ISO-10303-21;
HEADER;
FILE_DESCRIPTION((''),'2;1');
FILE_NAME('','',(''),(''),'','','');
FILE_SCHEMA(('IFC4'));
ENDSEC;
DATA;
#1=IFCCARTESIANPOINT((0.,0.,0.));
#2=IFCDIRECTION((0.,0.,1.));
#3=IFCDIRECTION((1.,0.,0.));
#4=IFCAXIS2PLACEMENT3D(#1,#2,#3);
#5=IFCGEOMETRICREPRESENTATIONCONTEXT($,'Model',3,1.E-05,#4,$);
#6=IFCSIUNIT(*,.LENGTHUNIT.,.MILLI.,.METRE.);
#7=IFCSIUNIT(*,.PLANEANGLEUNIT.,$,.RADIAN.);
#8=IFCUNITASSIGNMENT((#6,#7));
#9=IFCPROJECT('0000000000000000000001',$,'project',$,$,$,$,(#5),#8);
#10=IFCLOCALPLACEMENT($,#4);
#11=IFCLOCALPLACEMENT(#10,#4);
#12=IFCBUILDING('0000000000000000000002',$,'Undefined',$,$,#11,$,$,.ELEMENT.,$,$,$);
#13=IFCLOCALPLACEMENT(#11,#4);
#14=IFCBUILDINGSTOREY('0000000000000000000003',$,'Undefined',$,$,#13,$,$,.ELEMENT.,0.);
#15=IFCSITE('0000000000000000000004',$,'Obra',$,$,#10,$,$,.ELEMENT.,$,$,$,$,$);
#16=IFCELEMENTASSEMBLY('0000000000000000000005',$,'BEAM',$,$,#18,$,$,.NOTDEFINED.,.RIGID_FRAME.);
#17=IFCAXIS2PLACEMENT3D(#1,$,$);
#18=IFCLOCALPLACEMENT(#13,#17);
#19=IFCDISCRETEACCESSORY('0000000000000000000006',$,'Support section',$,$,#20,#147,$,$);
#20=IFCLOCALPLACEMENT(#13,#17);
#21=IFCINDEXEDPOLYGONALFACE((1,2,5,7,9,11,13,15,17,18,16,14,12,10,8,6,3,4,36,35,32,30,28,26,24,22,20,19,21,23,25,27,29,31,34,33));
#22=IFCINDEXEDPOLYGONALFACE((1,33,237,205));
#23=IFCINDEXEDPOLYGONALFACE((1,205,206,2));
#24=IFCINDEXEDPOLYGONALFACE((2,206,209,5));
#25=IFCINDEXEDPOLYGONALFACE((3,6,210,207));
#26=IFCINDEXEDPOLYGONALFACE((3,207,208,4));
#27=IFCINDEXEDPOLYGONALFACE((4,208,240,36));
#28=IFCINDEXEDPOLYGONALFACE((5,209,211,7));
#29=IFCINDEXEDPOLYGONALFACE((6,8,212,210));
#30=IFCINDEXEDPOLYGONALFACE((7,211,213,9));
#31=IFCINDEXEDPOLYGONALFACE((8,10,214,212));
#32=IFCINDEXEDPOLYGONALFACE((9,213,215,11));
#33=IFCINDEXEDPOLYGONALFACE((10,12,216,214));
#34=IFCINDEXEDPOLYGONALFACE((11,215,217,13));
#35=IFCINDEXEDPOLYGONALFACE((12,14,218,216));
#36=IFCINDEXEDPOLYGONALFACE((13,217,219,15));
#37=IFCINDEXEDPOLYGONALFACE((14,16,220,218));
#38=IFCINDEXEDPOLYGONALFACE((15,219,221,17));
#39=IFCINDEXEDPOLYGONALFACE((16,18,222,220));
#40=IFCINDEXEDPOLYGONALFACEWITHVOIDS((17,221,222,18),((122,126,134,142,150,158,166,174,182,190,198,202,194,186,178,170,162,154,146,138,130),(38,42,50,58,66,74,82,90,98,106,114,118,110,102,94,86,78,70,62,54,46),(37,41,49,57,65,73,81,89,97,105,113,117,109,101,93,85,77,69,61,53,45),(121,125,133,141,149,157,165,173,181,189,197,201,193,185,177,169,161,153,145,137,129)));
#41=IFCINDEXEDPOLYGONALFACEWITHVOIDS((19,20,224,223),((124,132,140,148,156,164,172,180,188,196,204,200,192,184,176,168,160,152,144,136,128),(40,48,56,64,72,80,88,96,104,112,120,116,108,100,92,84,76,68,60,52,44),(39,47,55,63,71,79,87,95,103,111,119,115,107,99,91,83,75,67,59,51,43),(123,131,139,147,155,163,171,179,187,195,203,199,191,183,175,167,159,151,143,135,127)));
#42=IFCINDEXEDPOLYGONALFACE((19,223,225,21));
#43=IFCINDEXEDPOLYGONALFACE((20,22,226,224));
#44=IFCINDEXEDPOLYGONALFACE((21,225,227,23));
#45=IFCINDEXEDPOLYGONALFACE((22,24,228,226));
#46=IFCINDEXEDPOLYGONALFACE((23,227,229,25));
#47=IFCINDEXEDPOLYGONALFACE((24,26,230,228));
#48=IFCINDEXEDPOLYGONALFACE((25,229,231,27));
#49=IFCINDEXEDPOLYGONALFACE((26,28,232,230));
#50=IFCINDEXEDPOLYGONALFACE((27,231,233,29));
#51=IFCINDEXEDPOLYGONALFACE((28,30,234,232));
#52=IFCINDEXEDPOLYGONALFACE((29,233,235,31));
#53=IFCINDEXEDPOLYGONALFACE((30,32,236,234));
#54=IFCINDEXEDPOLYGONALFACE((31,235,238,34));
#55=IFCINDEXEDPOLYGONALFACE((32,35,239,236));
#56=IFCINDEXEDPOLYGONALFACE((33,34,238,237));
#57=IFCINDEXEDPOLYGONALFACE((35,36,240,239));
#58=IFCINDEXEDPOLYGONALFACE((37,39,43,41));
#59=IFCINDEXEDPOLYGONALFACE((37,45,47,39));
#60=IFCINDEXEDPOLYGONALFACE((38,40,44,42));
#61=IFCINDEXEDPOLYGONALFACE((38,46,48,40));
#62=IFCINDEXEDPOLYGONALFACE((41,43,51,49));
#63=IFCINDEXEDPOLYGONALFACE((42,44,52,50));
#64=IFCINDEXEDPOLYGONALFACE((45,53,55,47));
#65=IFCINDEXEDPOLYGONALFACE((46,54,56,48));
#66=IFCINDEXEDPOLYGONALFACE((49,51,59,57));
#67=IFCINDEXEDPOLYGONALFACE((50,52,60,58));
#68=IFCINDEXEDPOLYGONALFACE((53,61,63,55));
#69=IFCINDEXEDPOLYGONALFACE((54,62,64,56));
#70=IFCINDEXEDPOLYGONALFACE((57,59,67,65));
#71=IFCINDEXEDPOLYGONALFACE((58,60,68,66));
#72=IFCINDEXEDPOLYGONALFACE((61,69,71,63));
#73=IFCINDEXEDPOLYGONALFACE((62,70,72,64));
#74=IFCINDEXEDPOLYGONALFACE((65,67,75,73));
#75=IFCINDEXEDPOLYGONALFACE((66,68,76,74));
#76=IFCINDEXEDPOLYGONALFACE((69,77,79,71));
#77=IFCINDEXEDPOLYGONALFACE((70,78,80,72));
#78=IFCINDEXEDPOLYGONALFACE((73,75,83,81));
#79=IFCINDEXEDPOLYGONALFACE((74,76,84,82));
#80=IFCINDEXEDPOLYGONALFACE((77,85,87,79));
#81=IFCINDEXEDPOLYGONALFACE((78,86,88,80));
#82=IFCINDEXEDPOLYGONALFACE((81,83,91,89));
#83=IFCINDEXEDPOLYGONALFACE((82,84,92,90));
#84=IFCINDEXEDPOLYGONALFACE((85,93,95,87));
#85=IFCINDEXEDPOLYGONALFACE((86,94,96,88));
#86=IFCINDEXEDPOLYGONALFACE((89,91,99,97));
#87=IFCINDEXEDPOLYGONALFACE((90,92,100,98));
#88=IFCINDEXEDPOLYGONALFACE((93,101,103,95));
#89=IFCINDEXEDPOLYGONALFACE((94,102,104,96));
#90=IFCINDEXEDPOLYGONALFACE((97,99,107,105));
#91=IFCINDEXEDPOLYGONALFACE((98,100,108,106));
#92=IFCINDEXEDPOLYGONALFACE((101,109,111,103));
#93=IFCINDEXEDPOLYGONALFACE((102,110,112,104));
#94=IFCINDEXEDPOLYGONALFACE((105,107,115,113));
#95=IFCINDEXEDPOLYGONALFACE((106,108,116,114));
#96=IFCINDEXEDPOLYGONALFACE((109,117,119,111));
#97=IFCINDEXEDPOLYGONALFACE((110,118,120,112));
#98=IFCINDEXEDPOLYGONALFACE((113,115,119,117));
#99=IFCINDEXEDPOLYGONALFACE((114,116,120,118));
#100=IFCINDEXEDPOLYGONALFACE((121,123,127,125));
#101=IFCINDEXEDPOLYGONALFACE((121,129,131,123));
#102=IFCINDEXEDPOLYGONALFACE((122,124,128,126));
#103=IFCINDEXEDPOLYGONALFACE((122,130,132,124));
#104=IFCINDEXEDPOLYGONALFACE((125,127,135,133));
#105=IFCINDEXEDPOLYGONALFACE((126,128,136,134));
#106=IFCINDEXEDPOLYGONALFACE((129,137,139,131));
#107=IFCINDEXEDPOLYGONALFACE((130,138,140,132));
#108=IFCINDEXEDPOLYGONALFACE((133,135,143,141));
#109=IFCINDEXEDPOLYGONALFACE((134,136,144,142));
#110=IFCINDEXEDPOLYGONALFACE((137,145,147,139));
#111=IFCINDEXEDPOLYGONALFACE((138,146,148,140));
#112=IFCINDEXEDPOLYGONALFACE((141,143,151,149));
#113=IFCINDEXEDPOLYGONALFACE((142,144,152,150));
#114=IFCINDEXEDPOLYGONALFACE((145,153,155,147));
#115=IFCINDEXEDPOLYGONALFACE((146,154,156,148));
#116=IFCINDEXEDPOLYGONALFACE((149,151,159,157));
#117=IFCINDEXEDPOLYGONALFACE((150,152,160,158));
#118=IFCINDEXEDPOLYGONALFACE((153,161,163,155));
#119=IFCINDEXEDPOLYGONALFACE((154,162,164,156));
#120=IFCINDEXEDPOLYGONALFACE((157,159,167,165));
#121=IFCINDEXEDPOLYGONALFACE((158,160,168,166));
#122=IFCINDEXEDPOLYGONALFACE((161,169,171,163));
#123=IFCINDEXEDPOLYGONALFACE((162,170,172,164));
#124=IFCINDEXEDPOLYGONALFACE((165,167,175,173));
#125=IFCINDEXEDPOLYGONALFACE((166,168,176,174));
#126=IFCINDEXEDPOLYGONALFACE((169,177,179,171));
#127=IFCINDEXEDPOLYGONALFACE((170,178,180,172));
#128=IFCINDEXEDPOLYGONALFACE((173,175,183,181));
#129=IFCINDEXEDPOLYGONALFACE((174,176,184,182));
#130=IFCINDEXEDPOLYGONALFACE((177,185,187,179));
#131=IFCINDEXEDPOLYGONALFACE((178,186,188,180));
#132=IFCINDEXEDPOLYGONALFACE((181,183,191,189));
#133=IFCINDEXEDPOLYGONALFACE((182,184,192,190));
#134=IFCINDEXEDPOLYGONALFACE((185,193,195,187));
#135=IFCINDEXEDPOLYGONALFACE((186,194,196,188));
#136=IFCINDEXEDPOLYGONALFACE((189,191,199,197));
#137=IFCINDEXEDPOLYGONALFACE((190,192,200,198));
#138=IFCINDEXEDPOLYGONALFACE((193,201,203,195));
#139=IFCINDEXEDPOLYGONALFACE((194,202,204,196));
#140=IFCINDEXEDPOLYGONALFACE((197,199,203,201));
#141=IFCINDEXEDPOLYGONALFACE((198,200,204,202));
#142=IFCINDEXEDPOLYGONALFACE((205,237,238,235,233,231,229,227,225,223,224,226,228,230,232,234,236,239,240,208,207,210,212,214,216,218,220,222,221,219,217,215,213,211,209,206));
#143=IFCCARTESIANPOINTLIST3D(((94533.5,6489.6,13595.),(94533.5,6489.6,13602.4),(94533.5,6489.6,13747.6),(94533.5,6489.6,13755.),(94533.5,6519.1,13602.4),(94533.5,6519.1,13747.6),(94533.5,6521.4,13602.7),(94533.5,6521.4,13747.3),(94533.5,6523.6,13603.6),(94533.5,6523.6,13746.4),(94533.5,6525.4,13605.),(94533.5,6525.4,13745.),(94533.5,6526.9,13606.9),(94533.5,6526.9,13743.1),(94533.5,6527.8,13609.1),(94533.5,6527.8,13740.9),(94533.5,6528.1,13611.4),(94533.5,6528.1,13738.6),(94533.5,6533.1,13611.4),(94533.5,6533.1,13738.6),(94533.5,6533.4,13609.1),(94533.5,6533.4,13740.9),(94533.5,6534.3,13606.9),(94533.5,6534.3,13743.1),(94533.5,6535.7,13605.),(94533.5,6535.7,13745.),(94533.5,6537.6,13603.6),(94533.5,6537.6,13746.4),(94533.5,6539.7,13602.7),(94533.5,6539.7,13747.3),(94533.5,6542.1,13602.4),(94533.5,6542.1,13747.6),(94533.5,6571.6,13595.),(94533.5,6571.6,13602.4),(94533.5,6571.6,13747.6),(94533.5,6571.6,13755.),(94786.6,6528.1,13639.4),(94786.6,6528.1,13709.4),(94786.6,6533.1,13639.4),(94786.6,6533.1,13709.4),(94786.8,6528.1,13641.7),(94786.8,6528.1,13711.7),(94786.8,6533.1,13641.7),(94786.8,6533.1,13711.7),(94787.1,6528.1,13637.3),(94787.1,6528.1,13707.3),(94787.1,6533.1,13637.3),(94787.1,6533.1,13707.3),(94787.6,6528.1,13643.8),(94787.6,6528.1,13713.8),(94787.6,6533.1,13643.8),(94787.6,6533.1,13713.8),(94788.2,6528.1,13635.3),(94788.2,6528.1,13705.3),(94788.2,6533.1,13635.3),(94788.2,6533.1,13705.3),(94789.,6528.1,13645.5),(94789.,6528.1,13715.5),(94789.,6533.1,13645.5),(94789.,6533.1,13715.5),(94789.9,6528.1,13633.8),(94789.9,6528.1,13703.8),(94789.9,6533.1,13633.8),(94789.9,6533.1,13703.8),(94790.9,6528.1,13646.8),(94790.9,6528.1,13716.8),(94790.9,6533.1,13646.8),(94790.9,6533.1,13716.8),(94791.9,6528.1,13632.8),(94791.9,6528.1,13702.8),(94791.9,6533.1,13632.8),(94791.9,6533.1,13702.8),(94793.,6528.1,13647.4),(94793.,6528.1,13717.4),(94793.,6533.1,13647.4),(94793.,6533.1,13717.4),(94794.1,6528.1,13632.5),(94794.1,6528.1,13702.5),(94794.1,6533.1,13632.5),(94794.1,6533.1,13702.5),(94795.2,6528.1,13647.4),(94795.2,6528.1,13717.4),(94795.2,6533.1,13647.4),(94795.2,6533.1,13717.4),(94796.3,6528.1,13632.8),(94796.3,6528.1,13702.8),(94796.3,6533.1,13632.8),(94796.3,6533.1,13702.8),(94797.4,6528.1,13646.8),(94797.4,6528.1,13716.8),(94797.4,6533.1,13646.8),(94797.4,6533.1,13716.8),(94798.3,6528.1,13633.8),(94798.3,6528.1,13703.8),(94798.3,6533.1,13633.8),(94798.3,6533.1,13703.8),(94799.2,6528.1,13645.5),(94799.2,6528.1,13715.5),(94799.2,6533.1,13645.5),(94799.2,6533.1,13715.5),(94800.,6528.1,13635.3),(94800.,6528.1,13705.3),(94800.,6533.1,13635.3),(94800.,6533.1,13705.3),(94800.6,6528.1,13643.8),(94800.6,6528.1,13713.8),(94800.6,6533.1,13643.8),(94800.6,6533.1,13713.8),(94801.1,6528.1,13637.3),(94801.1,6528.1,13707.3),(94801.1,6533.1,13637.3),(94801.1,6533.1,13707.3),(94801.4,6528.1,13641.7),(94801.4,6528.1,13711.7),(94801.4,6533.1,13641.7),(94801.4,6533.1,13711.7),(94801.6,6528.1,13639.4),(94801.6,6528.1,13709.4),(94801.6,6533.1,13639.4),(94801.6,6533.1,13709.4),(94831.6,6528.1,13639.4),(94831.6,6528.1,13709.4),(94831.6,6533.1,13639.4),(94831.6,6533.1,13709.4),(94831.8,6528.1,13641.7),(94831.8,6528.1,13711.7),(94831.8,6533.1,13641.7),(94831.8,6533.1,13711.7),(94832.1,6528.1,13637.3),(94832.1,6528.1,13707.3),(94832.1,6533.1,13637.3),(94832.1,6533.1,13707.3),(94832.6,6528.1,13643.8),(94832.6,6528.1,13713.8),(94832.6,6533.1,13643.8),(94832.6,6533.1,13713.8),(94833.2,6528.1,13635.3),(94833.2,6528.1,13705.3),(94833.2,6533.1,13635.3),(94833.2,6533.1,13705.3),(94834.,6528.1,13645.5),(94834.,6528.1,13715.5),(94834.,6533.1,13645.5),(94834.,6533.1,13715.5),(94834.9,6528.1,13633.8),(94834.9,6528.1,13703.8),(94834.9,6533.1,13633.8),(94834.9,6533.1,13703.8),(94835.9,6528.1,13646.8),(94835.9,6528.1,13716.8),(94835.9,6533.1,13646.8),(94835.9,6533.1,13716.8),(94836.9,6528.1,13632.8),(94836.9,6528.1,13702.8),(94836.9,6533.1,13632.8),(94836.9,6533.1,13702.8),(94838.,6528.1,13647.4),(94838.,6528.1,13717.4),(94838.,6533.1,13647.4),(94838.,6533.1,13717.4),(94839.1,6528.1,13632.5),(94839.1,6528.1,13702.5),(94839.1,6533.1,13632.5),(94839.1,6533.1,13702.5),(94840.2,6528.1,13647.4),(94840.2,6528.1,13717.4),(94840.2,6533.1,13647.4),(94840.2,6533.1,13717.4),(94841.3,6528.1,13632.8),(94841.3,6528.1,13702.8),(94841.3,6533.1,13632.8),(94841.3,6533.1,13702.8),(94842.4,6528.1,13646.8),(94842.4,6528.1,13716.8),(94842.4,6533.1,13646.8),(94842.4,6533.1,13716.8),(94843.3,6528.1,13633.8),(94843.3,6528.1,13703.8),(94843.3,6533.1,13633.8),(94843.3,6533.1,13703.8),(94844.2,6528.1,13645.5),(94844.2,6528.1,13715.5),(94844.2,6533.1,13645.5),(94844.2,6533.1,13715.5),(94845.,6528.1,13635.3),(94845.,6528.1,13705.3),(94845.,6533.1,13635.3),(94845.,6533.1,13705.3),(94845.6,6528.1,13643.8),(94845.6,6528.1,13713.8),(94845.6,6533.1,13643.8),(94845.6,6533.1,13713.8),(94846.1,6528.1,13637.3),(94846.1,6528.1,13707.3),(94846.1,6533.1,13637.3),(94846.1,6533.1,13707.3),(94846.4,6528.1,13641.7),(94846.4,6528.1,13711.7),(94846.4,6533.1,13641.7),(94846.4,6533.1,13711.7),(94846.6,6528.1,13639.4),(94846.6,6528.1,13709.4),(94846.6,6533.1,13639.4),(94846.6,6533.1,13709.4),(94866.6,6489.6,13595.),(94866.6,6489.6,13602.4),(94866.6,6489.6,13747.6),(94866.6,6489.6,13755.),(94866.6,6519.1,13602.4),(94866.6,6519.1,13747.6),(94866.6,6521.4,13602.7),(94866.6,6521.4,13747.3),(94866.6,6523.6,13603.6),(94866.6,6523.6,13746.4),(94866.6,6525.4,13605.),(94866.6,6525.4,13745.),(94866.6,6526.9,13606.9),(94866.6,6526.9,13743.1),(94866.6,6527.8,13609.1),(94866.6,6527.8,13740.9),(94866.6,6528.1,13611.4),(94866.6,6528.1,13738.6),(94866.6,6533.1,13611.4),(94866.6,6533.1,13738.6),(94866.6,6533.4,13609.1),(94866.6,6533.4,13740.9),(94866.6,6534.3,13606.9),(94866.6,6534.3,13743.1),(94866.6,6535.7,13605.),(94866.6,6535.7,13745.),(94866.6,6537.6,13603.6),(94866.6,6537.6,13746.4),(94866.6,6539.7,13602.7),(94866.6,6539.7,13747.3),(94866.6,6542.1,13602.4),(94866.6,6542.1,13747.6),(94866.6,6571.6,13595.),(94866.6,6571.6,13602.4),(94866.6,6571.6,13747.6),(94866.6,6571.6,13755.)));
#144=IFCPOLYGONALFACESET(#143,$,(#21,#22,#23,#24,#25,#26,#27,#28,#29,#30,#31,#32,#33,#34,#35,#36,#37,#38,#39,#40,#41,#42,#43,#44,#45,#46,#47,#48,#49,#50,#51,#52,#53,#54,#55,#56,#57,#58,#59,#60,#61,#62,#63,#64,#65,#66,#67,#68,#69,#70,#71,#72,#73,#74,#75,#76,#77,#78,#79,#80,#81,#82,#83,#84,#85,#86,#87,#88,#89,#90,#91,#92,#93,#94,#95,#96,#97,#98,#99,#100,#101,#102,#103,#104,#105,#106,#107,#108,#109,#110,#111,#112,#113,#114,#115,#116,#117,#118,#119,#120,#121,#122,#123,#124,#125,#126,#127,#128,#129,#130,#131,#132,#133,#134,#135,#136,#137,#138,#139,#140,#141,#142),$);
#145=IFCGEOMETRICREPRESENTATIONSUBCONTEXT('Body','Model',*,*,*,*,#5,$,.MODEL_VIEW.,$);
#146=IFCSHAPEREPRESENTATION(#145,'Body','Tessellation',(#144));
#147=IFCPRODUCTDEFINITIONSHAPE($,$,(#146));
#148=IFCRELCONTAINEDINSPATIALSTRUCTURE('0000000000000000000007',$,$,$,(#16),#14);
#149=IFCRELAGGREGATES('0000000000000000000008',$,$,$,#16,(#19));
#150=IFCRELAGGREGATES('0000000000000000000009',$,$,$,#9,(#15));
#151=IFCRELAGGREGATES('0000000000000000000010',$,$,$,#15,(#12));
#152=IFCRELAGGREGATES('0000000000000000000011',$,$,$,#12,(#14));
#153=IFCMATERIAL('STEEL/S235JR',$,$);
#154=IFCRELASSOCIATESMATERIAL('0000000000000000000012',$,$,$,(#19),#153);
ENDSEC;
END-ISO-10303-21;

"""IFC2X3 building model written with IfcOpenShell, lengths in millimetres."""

from ifc_helpers import new_model, si_unit, frame, origin_with_axes, origin_2d_with_axis, place, context, subcontext, project, spatial, circle, i_section, extrude, clip, halfspace, source, transform, mapped, material, element, aggregate, save


model = new_model("IFC2X3")

# Units and contexts
model_context = context("Model", 3, precision=1e-05, world=origin_with_axes())
body_context = subcontext(model_context, "Body", "Model", "MODEL_VIEW")
ifc_project = project(units=[si_unit("LENGTHUNIT", "METRE", prefix="MILLI"), si_unit("PLANEANGLEUNIT", "RADIAN")], contexts=[model_context])

# Site, building, storey
site_placement = place(None, origin_with_axes())
site = spatial("IfcSite", under=ifc_project, at=site_placement, Name="Obra", CompositionType="ELEMENT")
building_placement = place(site_placement, origin_with_axes())
building = spatial("IfcBuilding", under=site, at=building_placement, Name="Undefined", CompositionType="ELEMENT")
storey_placement = place(building_placement, origin_with_axes())
storey = spatial("IfcBuildingStorey", under=building, at=storey_placement, Name="Undefined", CompositionType="ELEMENT", Elevation=0.0)

# Shared definitions
ifc_material_1 = material(Name="STEEL/S235JR")

# Element assembly
assembly_1_placement = place(storey_placement, origin_with_axes())
assembly_1 = element("IfcElementAssembly", 1, at=assembly_1_placement, inside=storey, Name="BEAM", AssemblyPlace="NOTDEFINED", PredefinedType="RIGID_FRAME")

# Discrete accessory, opening
shared_shape_1 = source(origin_with_axes(), body_context, "Body", "SweptSolid", [
    extrude(circle(Radius=7.5, at=origin_2d_with_axis()), frame((0.0, -2.6, 0.0), z_axis=(0.0, 1.0, 0.0), x_axis=(1.0, 0.0, 0.0)), (0.0, 0.0, 1.0), 5.2),
])
discrete_accessory_1_placement = place(assembly_1_placement, frame((94533.6, 6530.6, 13675.0), z_axis=(0.0, 0.0, 1.0), x_axis=(1.0, 0.0, 0.0)))
discrete_accessory_1 = element("IfcDiscreteAccessory", 2, at=discrete_accessory_1_placement, material=ifc_material_1, Name="Support section", context=body_context, shape_type="Clipping", body=[
    clip(extrude(i_section(OverallWidth=82.0, OverallDepth=160.0, WebThickness=5.0, FlangeThickness=7.4, FilletRadius=9.0, at=origin_2d_with_axis()), frame((333.1, 0.0, 0.0), z_axis=(-1.0, 0.0, 0.0), x_axis=(0.0, -1.0, 0.0)), (0.0, 0.0, 1.0), 333.1), halfspace(frame((333.1, 0.0, -180.0), z_axis=(-1.0, 0.0, 0.0), x_axis=(0.0, 1.0, 0.0)), True)),
])
opening_1_placement = place(assembly_1_placement, frame((94816.6, 6530.6, 13710.0), z_axis=(-1.0, 0.0, 0.0), x_axis=(0.0, 0.0, -1.0)))
element("IfcOpeningElement", 3, at=opening_1_placement, cuts=discrete_accessory_1, ObjectType="Opening", context=body_context, shape_type="MappedRepresentation", body=[
    mapped(shared_shape_1, transform((0.0, 0.0, -22.5))),
    mapped(shared_shape_1, transform((70.0, 0.0, -22.5))),
    mapped(shared_shape_1, transform((0.0, 0.0, 22.5))),
    mapped(shared_shape_1, transform((70.0, 0.0, 22.5))),
])
aggregate(assembly_1, [discrete_accessory_1])

save(model, "model.ifc")
